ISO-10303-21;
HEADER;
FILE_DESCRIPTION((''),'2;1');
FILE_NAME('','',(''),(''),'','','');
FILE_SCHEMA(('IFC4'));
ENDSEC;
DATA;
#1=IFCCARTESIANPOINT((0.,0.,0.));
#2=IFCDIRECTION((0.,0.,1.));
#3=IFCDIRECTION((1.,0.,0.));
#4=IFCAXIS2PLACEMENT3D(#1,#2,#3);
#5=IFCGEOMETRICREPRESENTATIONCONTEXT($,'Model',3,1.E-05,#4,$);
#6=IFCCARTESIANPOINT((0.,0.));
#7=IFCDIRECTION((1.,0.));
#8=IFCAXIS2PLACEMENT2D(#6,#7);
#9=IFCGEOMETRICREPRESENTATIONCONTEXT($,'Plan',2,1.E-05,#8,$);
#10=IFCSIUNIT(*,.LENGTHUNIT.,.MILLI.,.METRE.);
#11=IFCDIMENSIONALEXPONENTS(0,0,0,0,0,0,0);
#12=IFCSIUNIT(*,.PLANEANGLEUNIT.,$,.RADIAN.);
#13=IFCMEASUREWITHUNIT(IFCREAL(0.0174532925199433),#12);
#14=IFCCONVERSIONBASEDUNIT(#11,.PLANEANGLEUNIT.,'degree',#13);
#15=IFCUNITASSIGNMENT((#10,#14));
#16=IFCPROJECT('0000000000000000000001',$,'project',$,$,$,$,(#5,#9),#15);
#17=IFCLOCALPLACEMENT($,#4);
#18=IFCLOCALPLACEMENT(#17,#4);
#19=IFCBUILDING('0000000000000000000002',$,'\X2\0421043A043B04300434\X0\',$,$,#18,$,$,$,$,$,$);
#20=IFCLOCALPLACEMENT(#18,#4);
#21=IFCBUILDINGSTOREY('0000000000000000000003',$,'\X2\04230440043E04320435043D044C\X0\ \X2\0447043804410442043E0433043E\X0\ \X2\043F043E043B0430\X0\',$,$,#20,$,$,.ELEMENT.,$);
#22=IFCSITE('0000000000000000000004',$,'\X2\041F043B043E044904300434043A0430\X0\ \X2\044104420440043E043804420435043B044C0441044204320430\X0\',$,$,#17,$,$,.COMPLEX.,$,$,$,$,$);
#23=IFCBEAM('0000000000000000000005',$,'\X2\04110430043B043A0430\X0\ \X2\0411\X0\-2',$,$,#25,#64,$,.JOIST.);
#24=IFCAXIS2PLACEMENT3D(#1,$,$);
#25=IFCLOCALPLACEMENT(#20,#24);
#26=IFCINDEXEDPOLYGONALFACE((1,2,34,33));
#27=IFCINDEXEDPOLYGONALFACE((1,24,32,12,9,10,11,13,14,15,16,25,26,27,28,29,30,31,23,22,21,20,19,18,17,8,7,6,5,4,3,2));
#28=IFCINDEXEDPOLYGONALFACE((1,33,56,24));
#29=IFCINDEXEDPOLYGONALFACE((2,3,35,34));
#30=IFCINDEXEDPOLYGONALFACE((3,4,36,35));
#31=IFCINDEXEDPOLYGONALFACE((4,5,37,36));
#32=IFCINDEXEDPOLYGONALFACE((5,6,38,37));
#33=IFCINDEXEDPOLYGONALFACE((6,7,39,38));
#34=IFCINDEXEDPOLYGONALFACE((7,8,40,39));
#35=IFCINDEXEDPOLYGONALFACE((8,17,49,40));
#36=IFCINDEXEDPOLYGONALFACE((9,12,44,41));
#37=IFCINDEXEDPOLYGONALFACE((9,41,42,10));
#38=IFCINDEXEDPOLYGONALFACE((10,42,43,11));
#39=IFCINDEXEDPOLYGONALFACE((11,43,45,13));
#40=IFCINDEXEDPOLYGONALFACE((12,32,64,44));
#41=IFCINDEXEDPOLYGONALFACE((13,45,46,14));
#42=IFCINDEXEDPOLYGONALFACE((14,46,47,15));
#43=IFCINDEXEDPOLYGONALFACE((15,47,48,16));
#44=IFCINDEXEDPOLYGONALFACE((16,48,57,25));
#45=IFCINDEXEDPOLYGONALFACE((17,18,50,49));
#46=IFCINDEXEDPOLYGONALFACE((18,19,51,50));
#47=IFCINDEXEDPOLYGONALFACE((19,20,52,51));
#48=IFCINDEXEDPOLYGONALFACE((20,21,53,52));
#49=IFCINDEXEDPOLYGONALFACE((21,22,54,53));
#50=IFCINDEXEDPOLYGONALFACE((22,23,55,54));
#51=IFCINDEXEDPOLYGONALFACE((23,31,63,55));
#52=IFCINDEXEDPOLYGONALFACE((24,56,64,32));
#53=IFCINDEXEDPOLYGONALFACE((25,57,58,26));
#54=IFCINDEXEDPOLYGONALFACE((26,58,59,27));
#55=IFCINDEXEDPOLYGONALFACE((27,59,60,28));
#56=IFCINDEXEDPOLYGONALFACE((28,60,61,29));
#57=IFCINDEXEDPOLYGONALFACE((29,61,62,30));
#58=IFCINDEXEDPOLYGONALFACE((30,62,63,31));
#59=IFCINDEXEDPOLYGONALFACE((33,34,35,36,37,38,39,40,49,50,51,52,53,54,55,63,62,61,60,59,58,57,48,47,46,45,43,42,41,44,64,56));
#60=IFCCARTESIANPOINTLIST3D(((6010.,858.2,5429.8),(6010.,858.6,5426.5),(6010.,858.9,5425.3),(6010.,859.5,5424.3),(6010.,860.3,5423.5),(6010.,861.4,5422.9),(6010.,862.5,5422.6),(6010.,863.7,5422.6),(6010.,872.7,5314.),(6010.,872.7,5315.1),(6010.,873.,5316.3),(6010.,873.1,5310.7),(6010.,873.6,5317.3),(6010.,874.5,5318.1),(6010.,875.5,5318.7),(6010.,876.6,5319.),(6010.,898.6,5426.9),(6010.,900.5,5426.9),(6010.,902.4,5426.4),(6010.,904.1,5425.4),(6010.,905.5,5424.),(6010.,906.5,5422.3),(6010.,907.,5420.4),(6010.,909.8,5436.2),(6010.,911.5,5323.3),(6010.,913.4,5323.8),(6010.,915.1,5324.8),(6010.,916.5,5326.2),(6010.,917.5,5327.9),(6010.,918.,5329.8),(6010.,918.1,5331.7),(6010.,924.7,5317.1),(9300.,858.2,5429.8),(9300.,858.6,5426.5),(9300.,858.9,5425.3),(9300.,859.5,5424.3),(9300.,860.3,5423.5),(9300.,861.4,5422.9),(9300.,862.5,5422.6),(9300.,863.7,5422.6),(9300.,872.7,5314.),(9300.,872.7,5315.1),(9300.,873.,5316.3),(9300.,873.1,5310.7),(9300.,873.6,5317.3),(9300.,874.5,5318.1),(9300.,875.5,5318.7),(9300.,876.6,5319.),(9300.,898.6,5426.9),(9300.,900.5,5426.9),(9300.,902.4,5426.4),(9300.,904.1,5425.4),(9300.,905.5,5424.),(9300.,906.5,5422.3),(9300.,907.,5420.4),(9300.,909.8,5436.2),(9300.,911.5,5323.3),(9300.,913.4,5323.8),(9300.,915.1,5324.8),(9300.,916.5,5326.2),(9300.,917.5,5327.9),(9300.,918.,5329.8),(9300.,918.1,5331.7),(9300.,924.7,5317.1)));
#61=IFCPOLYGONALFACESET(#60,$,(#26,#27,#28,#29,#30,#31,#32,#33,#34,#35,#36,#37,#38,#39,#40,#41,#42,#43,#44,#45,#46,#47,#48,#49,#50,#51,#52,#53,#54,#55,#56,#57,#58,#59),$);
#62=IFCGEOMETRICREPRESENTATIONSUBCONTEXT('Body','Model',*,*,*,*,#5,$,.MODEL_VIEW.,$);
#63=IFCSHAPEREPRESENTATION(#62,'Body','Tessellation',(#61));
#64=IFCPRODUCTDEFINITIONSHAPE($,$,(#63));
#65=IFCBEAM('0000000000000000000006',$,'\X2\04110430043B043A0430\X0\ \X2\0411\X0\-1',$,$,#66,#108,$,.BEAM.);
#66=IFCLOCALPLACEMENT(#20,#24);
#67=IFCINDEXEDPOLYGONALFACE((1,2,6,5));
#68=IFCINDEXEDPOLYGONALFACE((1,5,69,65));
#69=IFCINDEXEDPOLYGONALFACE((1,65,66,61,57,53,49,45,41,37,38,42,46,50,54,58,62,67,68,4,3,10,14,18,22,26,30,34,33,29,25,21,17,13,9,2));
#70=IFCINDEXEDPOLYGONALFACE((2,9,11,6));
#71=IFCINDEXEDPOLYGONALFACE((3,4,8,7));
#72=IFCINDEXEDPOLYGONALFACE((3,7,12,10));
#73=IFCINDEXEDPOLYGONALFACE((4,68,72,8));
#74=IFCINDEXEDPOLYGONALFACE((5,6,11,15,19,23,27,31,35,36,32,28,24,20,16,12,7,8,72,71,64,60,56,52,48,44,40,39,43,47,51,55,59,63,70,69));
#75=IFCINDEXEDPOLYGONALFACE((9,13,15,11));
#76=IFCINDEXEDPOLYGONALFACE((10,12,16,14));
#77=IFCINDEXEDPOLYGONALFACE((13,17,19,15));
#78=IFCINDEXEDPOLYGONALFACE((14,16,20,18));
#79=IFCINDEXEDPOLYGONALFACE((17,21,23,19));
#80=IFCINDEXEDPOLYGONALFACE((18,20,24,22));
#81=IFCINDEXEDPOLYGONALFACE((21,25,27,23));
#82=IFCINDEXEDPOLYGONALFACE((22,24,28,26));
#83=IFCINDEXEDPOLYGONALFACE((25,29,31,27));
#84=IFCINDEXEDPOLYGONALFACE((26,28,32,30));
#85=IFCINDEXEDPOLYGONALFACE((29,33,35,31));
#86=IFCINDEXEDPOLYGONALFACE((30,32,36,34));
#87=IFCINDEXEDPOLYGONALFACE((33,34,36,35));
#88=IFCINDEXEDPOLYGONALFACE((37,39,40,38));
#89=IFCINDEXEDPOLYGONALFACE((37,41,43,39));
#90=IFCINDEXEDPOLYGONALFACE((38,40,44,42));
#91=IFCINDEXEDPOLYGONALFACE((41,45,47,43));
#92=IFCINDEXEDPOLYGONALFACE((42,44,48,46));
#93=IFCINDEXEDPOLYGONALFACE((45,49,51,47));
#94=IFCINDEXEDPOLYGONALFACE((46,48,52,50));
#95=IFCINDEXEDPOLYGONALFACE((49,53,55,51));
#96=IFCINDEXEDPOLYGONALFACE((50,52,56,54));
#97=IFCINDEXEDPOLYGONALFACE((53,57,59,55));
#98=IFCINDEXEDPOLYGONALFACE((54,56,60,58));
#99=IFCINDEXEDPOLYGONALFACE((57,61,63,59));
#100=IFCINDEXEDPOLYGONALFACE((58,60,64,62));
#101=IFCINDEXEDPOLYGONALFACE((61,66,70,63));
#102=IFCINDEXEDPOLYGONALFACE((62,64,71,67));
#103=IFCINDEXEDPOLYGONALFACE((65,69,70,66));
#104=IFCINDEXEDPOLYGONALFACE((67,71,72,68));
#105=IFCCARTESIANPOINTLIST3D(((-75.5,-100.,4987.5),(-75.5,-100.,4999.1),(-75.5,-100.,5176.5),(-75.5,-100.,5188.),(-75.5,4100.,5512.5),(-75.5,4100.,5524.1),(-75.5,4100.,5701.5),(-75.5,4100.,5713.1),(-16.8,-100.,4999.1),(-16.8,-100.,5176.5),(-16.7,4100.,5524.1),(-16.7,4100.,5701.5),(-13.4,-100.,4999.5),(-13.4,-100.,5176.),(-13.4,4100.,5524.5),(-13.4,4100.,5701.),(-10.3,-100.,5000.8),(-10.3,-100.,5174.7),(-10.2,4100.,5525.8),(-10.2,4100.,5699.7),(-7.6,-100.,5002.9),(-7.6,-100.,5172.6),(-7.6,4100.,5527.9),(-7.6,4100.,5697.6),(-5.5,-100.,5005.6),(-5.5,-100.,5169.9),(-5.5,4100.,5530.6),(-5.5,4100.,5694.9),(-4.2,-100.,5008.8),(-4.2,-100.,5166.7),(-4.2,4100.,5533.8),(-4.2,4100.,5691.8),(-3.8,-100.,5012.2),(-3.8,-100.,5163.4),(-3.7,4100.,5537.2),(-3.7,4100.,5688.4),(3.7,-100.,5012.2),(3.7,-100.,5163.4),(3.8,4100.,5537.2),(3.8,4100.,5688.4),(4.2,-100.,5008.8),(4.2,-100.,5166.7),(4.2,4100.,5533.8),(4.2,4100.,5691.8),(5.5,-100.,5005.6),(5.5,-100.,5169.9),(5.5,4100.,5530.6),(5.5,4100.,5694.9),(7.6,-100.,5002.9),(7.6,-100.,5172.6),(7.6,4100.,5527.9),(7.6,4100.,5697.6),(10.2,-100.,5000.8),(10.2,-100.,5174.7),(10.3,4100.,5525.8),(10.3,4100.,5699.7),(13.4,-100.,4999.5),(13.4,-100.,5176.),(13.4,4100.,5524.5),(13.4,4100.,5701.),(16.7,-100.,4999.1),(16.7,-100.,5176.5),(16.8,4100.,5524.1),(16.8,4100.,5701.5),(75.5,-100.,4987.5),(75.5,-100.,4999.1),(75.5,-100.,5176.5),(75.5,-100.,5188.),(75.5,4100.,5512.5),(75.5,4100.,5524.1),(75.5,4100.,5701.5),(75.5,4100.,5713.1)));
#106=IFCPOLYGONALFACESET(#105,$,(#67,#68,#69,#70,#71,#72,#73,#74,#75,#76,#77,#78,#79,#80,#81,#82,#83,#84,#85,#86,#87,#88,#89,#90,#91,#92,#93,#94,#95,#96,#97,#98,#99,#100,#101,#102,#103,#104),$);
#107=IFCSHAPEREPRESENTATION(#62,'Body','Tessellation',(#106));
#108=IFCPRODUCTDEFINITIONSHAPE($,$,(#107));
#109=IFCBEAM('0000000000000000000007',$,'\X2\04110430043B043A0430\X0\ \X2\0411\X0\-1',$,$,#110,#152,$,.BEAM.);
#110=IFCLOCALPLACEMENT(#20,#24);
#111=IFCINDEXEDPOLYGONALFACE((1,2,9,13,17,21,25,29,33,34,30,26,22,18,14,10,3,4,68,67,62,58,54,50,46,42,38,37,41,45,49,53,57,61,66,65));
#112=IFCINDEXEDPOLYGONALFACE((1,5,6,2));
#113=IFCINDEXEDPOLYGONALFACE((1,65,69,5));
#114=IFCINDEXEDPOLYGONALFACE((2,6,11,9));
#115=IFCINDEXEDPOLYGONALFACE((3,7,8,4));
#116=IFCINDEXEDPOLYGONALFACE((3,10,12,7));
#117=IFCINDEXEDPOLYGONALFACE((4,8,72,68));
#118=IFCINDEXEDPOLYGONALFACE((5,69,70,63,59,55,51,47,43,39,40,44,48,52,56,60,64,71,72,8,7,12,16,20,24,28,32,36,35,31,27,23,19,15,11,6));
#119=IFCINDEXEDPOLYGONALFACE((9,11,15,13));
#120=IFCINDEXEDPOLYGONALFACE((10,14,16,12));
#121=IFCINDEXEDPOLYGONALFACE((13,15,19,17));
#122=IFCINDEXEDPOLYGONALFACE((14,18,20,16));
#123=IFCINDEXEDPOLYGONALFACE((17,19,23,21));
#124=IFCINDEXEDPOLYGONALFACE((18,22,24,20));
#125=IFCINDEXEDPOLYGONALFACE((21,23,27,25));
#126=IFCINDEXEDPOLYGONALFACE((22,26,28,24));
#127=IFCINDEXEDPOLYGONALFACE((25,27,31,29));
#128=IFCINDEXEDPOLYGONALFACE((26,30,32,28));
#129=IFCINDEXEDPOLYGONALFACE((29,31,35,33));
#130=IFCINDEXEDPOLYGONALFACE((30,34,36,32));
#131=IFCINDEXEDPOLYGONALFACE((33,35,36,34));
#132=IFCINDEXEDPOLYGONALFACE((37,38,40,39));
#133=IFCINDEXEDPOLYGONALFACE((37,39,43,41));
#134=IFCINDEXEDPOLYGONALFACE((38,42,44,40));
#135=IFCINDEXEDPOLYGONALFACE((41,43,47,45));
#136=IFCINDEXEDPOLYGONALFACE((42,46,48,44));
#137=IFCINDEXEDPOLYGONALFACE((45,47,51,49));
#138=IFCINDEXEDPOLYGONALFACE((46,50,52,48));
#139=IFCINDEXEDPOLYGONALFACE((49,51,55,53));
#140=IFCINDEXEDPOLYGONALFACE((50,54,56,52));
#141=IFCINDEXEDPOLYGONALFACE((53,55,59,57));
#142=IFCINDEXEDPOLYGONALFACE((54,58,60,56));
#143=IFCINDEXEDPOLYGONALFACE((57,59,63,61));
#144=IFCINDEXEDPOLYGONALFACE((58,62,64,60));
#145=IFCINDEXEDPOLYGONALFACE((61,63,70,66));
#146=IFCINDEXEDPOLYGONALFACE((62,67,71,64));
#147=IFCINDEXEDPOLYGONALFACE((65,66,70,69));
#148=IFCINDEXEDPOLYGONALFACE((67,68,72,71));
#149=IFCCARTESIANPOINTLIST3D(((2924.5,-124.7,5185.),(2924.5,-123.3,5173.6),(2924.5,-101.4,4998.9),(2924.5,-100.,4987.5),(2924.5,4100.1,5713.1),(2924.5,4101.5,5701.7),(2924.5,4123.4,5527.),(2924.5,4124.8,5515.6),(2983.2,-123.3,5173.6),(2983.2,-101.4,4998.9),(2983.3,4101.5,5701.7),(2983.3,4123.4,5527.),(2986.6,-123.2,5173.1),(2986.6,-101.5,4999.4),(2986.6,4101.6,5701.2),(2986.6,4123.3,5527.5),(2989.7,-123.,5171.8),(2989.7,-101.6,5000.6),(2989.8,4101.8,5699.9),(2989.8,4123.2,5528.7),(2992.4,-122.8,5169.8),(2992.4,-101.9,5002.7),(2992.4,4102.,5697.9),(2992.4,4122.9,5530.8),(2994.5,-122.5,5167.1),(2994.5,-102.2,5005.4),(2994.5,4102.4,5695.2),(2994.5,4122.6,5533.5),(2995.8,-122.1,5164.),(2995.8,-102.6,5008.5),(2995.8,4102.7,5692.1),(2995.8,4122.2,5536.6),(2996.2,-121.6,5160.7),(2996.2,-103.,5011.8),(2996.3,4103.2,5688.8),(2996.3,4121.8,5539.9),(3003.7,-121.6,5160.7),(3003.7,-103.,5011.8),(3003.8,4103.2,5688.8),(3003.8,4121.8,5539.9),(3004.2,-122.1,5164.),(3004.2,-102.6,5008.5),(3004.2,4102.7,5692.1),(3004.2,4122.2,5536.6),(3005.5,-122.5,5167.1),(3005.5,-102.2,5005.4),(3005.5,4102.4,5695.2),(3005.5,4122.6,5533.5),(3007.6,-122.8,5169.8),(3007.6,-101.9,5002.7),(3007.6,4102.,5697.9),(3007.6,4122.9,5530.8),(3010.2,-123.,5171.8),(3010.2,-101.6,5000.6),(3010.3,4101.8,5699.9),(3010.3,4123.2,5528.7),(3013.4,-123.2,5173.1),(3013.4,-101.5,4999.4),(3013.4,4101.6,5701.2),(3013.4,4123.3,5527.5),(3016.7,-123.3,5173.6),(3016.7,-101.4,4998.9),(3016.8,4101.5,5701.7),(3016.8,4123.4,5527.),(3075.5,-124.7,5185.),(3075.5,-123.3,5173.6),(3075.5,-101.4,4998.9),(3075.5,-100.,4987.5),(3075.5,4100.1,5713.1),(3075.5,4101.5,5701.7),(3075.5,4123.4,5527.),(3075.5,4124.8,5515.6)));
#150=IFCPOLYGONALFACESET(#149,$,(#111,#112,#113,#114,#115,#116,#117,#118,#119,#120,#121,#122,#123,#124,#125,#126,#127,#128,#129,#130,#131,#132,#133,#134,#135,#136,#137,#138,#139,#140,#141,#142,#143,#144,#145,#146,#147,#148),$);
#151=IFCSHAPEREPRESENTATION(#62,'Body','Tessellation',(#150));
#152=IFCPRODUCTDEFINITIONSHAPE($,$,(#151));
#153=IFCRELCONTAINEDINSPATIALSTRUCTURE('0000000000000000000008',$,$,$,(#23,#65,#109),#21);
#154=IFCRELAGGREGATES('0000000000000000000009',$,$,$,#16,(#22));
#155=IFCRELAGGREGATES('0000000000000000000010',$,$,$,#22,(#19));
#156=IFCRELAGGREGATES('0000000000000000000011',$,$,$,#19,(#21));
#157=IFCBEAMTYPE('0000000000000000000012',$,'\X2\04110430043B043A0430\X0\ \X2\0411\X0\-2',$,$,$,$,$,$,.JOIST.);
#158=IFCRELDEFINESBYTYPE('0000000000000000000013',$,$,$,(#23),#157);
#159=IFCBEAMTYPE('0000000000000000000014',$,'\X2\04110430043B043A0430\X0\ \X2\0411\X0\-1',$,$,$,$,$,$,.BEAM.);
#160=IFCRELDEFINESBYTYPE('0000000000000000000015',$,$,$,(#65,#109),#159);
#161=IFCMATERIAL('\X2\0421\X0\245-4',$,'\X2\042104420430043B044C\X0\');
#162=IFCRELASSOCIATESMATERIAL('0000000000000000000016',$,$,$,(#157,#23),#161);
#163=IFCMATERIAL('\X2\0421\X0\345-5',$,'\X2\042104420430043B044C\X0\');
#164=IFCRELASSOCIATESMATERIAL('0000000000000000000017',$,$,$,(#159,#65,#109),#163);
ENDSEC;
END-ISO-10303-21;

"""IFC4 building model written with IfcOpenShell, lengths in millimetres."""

from ifc_helpers import new_model, entity, si_unit, converted_unit, frame, origin_with_axes, origin_2d_with_axis, place, context, subcontext, project, spatial, i_section, u_section, extrude, clip, halfspace, material, material_profile, profile_set, profile_usage, type_object, element, save


model = new_model("IFC4")

# Units and contexts
model_context = context("Model", 3, precision=1e-05, world=origin_with_axes())
plan_context = context("Plan", 2, precision=1e-05, world=origin_2d_with_axis())
body_context = subcontext(model_context, "Body", "Model", "MODEL_VIEW")
ifc_project = project(units=[si_unit("LENGTHUNIT", "METRE", prefix="MILLI"), converted_unit("PLANEANGLEUNIT", "degree", entity("IfcReal", 0.0174532925199433), si_unit("PLANEANGLEUNIT", "RADIAN"), dimensions=[0, 0, 0, 0, 0, 0, 0])], contexts=[model_context, plan_context])

# Site, building, storey
site_placement = place(None, origin_with_axes())
site = spatial("IfcSite", under=ifc_project, at=site_placement, Name="Площадка строительства", CompositionType="COMPLEX")
building_placement = place(site_placement, origin_with_axes())
building = spatial("IfcBuilding", under=site, at=building_placement, Name="Склад")
storey_placement = place(building_placement, origin_with_axes())
storey = spatial("IfcBuildingStorey", under=building, at=storey_placement, Name="Уровень чистого пола", CompositionType="ELEMENT")

# Shared definitions
ifc_material_1 = material(Name="С345-5", Category="Сталь")

# Beams
ifc_material_2 = material(Name="С245-4", Category="Сталь")
ifc_material_profile_1 = material_profile(ifc_material_2, u_section(Depth=120.0, FlangeWidth=52.0, WebThickness=4.8, FlangeThickness=7.8, FilletRadius=7.5, EdgeRadius=4.5, FlangeSlope=0.0))
ifc_profile_set_1 = profile_set([ifc_material_profile_1], Name="U12P_S245-4")
beam_type_1 = type_object("IfcBeamType", Name="Балка Б-2", PredefinedType="JOIST", material=ifc_profile_set_1)
ifc_profile_usage_1 = profile_usage(ifc_profile_set_1, cardinal=3)
beam_1_placement = place(storey_placement, frame((9300.0, 924.7, 5317.1), z_axis=(-1.0, 0.0, 0.0), x_axis=(0.0, -0.99228, -0.12402)))
element("IfcBeam", 1, at=beam_1_placement, inside=storey, type_object=beam_type_1, material=ifc_profile_usage_1, Name="Балка Б-2", PredefinedType="JOIST", context=body_context, shape_type="SweptSolid", body=[
    extrude(u_section(Depth=120.0, FlangeWidth=52.0, WebThickness=4.8, FlangeThickness=7.8, FilletRadius=7.5, EdgeRadius=4.5, FlangeSlope=0.0), frame((26.0, 60.0, 0.0), z_axis=(0.0, 0.0, 1.0), x_axis=(1.0, 0.0, 0.0)), (0.0, 0.0, 1.0), 3290.0),
])
ifc_material_profile_2 = material_profile(ifc_material_1, i_section(OverallWidth=151.0, OverallDepth=199.0, WebThickness=7.5, FlangeThickness=11.5, FilletRadius=13.0, FlangeEdgeRadius=0.0, FlangeSlope=0.0))
ifc_profile_set_2 = profile_set([ifc_material_profile_2], Name="I20H2_S345-5")
ifc_profile_usage_2 = profile_usage(ifc_profile_set_2, cardinal=2)
beam_type_2 = type_object("IfcBeamType", Name="Балка Б-1", PredefinedType="BEAM", material=ifc_profile_set_2)
beam_2_placement = place(storey_placement, frame((0.0, -298.5, 4962.7), z_axis=(0.0, 0.992278, 0.124035), x_axis=(-1.0, 0.0, 0.0)))
element("IfcBeam", 2, at=beam_2_placement, inside=storey, type_object=beam_type_2, material=ifc_profile_usage_2, Name="Балка Б-1", PredefinedType="BEAM", context=body_context, shape_type="Clipping", body=[
    clip(clip(extrude(i_section(OverallWidth=151.0, OverallDepth=199.0, WebThickness=7.5, FlangeThickness=11.5, FilletRadius=13.0, FlangeEdgeRadius=0.0, FlangeSlope=0.0), frame((0.0, 99.5, 0.0), z_axis=(0.0, 0.0, 1.0), x_axis=(1.0, 0.0, 0.0)), (0.0, 0.0, 1.0), 4632.7), halfspace(frame((0.0, -5469.9, 3748.9), z_axis=(0.0, -0.124035, 0.992278), x_axis=(0.0, 0.992278, 0.124035)), False)), halfspace(frame((0.0, -4949.0, -418.6), z_axis=(0.0, 0.124035, -0.992278), x_axis=(0.0, 0.992278, 0.124035)), False)),
])
ifc_profile_usage_3 = profile_usage(ifc_profile_set_2, cardinal=2)
beam_3_placement = place(storey_placement, frame((3000.0, -100.0, 4987.5), z_axis=(0.0, 0.992278, 0.124035), x_axis=(-1.0, 0.0, 0.0)))
element("IfcBeam", 3, at=beam_3_placement, inside=storey, type_object=beam_type_2, material=ifc_profile_usage_3, Name="Балка Б-1", PredefinedType="BEAM", context=body_context, shape_type="SweptSolid", body=[
    extrude(i_section(OverallWidth=151.0, OverallDepth=199.0, WebThickness=7.5, FlangeThickness=11.5, FilletRadius=13.0, FlangeEdgeRadius=0.0, FlangeSlope=0.0), frame((0.0, 99.5, 0.0), z_axis=(0.0, 0.0, 1.0), x_axis=(1.0, 0.0, 0.0)), (0.0, 0.0, 1.0), 4257.7),
])

save(model, "model.ifc")
